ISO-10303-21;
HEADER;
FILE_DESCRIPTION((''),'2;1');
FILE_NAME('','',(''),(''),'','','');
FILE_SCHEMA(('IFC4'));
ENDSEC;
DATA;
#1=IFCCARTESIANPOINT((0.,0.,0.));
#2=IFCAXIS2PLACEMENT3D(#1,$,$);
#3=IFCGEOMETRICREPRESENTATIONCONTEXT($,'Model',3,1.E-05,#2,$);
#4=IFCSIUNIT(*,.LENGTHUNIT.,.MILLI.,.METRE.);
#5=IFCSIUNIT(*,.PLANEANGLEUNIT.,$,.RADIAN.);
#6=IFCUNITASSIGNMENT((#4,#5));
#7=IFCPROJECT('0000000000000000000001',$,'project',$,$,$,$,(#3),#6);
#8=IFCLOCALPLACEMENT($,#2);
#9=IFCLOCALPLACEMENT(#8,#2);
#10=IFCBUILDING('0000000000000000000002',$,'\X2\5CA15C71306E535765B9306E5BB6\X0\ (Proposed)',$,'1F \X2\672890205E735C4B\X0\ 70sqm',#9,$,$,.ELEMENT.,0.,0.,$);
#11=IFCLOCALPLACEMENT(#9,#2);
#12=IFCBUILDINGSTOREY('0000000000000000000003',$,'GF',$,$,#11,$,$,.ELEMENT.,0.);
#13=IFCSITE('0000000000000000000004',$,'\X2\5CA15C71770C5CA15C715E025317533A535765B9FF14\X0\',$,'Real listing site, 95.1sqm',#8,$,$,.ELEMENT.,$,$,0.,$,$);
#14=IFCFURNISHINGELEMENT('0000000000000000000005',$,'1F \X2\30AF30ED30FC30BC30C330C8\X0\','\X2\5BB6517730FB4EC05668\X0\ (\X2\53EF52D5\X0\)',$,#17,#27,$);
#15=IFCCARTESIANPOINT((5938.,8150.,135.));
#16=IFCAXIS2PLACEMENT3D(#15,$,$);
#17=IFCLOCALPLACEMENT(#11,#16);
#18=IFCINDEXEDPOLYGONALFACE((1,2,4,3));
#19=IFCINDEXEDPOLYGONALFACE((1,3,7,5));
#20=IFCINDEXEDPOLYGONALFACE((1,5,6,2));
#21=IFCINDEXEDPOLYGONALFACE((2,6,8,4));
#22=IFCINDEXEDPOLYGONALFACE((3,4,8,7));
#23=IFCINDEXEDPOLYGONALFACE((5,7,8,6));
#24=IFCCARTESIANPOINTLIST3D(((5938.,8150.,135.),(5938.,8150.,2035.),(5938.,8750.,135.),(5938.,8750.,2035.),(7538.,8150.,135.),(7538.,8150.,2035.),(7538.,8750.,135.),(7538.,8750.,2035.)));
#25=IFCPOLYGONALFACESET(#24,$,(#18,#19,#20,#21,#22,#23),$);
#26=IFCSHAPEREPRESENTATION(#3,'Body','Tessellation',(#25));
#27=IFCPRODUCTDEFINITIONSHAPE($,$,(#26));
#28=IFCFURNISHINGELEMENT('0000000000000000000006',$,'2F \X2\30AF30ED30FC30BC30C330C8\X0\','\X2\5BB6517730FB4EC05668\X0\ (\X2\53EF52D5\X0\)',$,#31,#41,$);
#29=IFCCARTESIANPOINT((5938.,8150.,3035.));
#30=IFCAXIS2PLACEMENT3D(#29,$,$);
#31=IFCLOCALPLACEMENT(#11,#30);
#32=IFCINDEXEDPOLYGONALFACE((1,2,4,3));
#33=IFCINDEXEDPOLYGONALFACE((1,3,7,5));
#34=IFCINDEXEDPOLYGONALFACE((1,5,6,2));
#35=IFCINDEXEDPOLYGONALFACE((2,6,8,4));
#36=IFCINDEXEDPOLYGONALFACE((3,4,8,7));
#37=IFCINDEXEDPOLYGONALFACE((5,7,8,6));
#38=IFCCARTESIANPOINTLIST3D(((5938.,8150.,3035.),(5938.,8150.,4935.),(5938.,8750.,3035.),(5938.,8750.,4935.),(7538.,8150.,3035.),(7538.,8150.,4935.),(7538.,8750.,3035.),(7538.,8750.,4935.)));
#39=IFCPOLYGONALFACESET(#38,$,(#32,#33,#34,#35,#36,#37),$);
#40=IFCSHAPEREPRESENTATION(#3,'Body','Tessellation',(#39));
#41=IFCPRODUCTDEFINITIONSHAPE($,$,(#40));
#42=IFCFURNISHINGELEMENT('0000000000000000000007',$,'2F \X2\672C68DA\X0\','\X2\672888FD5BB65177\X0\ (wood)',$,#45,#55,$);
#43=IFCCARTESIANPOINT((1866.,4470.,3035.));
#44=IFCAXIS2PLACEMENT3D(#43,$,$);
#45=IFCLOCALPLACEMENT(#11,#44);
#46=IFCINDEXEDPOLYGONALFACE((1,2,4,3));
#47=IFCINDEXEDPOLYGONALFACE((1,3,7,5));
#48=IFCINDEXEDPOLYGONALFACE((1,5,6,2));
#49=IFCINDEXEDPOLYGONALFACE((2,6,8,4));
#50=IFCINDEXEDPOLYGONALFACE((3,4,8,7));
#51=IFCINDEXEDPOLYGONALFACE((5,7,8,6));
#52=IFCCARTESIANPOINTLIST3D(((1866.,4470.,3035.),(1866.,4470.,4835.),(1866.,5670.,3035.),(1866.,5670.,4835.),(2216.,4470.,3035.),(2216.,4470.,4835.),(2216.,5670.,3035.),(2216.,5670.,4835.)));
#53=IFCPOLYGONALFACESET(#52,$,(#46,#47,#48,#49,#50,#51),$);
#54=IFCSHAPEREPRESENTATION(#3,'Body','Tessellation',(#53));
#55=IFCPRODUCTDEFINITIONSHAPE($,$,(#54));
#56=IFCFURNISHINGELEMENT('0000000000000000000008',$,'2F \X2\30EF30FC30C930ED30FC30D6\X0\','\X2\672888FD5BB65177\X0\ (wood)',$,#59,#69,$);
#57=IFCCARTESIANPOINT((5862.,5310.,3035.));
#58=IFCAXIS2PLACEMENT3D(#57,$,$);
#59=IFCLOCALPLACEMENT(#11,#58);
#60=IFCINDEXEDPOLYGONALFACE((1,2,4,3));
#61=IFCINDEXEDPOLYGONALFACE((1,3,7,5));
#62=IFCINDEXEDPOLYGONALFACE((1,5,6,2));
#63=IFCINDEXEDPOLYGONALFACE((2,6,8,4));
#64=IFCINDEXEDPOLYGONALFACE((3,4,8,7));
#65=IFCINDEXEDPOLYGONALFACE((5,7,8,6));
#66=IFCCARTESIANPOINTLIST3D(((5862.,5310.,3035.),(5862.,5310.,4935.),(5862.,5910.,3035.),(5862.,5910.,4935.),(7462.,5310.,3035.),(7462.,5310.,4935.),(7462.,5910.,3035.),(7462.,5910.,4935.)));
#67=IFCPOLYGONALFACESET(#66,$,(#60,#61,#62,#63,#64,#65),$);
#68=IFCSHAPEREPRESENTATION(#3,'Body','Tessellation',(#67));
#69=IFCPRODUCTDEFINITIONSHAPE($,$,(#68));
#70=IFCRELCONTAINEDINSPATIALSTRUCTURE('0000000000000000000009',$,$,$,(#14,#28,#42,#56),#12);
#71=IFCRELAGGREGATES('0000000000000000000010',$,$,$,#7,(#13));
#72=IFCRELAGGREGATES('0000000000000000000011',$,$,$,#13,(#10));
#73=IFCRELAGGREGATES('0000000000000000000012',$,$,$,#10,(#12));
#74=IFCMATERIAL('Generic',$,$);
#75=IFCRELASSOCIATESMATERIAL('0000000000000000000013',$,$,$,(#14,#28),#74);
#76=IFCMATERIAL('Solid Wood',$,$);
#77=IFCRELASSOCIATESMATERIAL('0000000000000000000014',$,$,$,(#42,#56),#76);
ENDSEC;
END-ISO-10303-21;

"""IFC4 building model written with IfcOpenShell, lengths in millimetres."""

from ifc_helpers import new_model, si_unit, frame, frame_2d, origin, place, context, project, spatial, rectangle, extrude, material, element, save


model = new_model("IFC4")

# Units and contexts
model_context = context("Model", 3, precision=1e-05, world=origin())
ifc_project = project(units=[si_unit("LENGTHUNIT", "METRE", prefix="MILLI"), si_unit("PLANEANGLEUNIT", "RADIAN")], contexts=[model_context])

# Site, building, storey
site_placement = place(None, origin())
site = spatial("IfcSite", under=ifc_project, at=site_placement, Name="岡山県岡山市北区南方４", ObjectType="Real listing site, 95.1sqm", CompositionType="ELEMENT", RefElevation=0.0)
building_placement = place(site_placement, origin())
building = spatial("IfcBuilding", under=site, at=building_placement, Name="岡山の南方の家 (Proposed)", ObjectType="1F 木造平屋 70sqm", CompositionType="ELEMENT", ElevationOfRefHeight=0.0, ElevationOfTerrain=0.0)
storey_placement = place(building_placement, origin())
storey = spatial("IfcBuildingStorey", under=building, at=storey_placement, Name="GF", CompositionType="ELEMENT", Elevation=0.0)

# Shared definitions
ifc_material_1 = material(Name="Solid Wood")

# Shared definitions
ifc_material_2 = material(Name="Generic")

# Furnishing elements
furnishing_1_placement = place(storey_placement, frame((5938.0, 8150.0, 135.0)))
element("IfcFurnishingElement", 1, at=furnishing_1_placement, inside=storey, material=ifc_material_2, Name="1F クローゼット", Description="家具・什器 (可動)", context=model_context, shape_type="SweptSolid", body=[
    extrude(rectangle(XDim=1600.0, YDim=600.0, at=frame_2d((800.0, 300.0))), frame((5938.0, 8150.0, 135.0)), (0.0, 0.0, 1.0), 1900.0),
])
furnishing_2_placement = place(storey_placement, frame((5938.0, 8150.0, 3035.0)))
element("IfcFurnishingElement", 2, at=furnishing_2_placement, inside=storey, material=ifc_material_2, Name="2F クローゼット", Description="家具・什器 (可動)", context=model_context, shape_type="SweptSolid", body=[
    extrude(rectangle(XDim=1600.0, YDim=600.0, at=frame_2d((800.0, 300.0))), frame((5938.0, 8150.0, 3035.0)), (0.0, 0.0, 1.0), 1900.0),
])
furnishing_3_placement = place(storey_placement, frame((1866.0, 4470.0, 3035.0)))
element("IfcFurnishingElement", 3, at=furnishing_3_placement, inside=storey, material=ifc_material_1, Name="2F 本棚", Description="木製家具 (wood)", context=model_context, shape_type="SweptSolid", body=[
    extrude(rectangle(XDim=350.0, YDim=1200.0, at=frame_2d((175.0, 600.0))), frame((1866.0, 4470.0, 3035.0)), (0.0, 0.0, 1.0), 1800.0),
])
furnishing_4_placement = place(storey_placement, frame((5862.0, 5310.0, 3035.0)))
element("IfcFurnishingElement", 4, at=furnishing_4_placement, inside=storey, material=ifc_material_1, Name="2F ワードローブ", Description="木製家具 (wood)", context=model_context, shape_type="SweptSolid", body=[
    extrude(rectangle(XDim=1600.0, YDim=600.0, at=frame_2d((800.0, 300.0))), frame((5862.0, 5310.0, 3035.0)), (0.0, 0.0, 1.0), 1900.0),
])

save(model, "model.ifc")
